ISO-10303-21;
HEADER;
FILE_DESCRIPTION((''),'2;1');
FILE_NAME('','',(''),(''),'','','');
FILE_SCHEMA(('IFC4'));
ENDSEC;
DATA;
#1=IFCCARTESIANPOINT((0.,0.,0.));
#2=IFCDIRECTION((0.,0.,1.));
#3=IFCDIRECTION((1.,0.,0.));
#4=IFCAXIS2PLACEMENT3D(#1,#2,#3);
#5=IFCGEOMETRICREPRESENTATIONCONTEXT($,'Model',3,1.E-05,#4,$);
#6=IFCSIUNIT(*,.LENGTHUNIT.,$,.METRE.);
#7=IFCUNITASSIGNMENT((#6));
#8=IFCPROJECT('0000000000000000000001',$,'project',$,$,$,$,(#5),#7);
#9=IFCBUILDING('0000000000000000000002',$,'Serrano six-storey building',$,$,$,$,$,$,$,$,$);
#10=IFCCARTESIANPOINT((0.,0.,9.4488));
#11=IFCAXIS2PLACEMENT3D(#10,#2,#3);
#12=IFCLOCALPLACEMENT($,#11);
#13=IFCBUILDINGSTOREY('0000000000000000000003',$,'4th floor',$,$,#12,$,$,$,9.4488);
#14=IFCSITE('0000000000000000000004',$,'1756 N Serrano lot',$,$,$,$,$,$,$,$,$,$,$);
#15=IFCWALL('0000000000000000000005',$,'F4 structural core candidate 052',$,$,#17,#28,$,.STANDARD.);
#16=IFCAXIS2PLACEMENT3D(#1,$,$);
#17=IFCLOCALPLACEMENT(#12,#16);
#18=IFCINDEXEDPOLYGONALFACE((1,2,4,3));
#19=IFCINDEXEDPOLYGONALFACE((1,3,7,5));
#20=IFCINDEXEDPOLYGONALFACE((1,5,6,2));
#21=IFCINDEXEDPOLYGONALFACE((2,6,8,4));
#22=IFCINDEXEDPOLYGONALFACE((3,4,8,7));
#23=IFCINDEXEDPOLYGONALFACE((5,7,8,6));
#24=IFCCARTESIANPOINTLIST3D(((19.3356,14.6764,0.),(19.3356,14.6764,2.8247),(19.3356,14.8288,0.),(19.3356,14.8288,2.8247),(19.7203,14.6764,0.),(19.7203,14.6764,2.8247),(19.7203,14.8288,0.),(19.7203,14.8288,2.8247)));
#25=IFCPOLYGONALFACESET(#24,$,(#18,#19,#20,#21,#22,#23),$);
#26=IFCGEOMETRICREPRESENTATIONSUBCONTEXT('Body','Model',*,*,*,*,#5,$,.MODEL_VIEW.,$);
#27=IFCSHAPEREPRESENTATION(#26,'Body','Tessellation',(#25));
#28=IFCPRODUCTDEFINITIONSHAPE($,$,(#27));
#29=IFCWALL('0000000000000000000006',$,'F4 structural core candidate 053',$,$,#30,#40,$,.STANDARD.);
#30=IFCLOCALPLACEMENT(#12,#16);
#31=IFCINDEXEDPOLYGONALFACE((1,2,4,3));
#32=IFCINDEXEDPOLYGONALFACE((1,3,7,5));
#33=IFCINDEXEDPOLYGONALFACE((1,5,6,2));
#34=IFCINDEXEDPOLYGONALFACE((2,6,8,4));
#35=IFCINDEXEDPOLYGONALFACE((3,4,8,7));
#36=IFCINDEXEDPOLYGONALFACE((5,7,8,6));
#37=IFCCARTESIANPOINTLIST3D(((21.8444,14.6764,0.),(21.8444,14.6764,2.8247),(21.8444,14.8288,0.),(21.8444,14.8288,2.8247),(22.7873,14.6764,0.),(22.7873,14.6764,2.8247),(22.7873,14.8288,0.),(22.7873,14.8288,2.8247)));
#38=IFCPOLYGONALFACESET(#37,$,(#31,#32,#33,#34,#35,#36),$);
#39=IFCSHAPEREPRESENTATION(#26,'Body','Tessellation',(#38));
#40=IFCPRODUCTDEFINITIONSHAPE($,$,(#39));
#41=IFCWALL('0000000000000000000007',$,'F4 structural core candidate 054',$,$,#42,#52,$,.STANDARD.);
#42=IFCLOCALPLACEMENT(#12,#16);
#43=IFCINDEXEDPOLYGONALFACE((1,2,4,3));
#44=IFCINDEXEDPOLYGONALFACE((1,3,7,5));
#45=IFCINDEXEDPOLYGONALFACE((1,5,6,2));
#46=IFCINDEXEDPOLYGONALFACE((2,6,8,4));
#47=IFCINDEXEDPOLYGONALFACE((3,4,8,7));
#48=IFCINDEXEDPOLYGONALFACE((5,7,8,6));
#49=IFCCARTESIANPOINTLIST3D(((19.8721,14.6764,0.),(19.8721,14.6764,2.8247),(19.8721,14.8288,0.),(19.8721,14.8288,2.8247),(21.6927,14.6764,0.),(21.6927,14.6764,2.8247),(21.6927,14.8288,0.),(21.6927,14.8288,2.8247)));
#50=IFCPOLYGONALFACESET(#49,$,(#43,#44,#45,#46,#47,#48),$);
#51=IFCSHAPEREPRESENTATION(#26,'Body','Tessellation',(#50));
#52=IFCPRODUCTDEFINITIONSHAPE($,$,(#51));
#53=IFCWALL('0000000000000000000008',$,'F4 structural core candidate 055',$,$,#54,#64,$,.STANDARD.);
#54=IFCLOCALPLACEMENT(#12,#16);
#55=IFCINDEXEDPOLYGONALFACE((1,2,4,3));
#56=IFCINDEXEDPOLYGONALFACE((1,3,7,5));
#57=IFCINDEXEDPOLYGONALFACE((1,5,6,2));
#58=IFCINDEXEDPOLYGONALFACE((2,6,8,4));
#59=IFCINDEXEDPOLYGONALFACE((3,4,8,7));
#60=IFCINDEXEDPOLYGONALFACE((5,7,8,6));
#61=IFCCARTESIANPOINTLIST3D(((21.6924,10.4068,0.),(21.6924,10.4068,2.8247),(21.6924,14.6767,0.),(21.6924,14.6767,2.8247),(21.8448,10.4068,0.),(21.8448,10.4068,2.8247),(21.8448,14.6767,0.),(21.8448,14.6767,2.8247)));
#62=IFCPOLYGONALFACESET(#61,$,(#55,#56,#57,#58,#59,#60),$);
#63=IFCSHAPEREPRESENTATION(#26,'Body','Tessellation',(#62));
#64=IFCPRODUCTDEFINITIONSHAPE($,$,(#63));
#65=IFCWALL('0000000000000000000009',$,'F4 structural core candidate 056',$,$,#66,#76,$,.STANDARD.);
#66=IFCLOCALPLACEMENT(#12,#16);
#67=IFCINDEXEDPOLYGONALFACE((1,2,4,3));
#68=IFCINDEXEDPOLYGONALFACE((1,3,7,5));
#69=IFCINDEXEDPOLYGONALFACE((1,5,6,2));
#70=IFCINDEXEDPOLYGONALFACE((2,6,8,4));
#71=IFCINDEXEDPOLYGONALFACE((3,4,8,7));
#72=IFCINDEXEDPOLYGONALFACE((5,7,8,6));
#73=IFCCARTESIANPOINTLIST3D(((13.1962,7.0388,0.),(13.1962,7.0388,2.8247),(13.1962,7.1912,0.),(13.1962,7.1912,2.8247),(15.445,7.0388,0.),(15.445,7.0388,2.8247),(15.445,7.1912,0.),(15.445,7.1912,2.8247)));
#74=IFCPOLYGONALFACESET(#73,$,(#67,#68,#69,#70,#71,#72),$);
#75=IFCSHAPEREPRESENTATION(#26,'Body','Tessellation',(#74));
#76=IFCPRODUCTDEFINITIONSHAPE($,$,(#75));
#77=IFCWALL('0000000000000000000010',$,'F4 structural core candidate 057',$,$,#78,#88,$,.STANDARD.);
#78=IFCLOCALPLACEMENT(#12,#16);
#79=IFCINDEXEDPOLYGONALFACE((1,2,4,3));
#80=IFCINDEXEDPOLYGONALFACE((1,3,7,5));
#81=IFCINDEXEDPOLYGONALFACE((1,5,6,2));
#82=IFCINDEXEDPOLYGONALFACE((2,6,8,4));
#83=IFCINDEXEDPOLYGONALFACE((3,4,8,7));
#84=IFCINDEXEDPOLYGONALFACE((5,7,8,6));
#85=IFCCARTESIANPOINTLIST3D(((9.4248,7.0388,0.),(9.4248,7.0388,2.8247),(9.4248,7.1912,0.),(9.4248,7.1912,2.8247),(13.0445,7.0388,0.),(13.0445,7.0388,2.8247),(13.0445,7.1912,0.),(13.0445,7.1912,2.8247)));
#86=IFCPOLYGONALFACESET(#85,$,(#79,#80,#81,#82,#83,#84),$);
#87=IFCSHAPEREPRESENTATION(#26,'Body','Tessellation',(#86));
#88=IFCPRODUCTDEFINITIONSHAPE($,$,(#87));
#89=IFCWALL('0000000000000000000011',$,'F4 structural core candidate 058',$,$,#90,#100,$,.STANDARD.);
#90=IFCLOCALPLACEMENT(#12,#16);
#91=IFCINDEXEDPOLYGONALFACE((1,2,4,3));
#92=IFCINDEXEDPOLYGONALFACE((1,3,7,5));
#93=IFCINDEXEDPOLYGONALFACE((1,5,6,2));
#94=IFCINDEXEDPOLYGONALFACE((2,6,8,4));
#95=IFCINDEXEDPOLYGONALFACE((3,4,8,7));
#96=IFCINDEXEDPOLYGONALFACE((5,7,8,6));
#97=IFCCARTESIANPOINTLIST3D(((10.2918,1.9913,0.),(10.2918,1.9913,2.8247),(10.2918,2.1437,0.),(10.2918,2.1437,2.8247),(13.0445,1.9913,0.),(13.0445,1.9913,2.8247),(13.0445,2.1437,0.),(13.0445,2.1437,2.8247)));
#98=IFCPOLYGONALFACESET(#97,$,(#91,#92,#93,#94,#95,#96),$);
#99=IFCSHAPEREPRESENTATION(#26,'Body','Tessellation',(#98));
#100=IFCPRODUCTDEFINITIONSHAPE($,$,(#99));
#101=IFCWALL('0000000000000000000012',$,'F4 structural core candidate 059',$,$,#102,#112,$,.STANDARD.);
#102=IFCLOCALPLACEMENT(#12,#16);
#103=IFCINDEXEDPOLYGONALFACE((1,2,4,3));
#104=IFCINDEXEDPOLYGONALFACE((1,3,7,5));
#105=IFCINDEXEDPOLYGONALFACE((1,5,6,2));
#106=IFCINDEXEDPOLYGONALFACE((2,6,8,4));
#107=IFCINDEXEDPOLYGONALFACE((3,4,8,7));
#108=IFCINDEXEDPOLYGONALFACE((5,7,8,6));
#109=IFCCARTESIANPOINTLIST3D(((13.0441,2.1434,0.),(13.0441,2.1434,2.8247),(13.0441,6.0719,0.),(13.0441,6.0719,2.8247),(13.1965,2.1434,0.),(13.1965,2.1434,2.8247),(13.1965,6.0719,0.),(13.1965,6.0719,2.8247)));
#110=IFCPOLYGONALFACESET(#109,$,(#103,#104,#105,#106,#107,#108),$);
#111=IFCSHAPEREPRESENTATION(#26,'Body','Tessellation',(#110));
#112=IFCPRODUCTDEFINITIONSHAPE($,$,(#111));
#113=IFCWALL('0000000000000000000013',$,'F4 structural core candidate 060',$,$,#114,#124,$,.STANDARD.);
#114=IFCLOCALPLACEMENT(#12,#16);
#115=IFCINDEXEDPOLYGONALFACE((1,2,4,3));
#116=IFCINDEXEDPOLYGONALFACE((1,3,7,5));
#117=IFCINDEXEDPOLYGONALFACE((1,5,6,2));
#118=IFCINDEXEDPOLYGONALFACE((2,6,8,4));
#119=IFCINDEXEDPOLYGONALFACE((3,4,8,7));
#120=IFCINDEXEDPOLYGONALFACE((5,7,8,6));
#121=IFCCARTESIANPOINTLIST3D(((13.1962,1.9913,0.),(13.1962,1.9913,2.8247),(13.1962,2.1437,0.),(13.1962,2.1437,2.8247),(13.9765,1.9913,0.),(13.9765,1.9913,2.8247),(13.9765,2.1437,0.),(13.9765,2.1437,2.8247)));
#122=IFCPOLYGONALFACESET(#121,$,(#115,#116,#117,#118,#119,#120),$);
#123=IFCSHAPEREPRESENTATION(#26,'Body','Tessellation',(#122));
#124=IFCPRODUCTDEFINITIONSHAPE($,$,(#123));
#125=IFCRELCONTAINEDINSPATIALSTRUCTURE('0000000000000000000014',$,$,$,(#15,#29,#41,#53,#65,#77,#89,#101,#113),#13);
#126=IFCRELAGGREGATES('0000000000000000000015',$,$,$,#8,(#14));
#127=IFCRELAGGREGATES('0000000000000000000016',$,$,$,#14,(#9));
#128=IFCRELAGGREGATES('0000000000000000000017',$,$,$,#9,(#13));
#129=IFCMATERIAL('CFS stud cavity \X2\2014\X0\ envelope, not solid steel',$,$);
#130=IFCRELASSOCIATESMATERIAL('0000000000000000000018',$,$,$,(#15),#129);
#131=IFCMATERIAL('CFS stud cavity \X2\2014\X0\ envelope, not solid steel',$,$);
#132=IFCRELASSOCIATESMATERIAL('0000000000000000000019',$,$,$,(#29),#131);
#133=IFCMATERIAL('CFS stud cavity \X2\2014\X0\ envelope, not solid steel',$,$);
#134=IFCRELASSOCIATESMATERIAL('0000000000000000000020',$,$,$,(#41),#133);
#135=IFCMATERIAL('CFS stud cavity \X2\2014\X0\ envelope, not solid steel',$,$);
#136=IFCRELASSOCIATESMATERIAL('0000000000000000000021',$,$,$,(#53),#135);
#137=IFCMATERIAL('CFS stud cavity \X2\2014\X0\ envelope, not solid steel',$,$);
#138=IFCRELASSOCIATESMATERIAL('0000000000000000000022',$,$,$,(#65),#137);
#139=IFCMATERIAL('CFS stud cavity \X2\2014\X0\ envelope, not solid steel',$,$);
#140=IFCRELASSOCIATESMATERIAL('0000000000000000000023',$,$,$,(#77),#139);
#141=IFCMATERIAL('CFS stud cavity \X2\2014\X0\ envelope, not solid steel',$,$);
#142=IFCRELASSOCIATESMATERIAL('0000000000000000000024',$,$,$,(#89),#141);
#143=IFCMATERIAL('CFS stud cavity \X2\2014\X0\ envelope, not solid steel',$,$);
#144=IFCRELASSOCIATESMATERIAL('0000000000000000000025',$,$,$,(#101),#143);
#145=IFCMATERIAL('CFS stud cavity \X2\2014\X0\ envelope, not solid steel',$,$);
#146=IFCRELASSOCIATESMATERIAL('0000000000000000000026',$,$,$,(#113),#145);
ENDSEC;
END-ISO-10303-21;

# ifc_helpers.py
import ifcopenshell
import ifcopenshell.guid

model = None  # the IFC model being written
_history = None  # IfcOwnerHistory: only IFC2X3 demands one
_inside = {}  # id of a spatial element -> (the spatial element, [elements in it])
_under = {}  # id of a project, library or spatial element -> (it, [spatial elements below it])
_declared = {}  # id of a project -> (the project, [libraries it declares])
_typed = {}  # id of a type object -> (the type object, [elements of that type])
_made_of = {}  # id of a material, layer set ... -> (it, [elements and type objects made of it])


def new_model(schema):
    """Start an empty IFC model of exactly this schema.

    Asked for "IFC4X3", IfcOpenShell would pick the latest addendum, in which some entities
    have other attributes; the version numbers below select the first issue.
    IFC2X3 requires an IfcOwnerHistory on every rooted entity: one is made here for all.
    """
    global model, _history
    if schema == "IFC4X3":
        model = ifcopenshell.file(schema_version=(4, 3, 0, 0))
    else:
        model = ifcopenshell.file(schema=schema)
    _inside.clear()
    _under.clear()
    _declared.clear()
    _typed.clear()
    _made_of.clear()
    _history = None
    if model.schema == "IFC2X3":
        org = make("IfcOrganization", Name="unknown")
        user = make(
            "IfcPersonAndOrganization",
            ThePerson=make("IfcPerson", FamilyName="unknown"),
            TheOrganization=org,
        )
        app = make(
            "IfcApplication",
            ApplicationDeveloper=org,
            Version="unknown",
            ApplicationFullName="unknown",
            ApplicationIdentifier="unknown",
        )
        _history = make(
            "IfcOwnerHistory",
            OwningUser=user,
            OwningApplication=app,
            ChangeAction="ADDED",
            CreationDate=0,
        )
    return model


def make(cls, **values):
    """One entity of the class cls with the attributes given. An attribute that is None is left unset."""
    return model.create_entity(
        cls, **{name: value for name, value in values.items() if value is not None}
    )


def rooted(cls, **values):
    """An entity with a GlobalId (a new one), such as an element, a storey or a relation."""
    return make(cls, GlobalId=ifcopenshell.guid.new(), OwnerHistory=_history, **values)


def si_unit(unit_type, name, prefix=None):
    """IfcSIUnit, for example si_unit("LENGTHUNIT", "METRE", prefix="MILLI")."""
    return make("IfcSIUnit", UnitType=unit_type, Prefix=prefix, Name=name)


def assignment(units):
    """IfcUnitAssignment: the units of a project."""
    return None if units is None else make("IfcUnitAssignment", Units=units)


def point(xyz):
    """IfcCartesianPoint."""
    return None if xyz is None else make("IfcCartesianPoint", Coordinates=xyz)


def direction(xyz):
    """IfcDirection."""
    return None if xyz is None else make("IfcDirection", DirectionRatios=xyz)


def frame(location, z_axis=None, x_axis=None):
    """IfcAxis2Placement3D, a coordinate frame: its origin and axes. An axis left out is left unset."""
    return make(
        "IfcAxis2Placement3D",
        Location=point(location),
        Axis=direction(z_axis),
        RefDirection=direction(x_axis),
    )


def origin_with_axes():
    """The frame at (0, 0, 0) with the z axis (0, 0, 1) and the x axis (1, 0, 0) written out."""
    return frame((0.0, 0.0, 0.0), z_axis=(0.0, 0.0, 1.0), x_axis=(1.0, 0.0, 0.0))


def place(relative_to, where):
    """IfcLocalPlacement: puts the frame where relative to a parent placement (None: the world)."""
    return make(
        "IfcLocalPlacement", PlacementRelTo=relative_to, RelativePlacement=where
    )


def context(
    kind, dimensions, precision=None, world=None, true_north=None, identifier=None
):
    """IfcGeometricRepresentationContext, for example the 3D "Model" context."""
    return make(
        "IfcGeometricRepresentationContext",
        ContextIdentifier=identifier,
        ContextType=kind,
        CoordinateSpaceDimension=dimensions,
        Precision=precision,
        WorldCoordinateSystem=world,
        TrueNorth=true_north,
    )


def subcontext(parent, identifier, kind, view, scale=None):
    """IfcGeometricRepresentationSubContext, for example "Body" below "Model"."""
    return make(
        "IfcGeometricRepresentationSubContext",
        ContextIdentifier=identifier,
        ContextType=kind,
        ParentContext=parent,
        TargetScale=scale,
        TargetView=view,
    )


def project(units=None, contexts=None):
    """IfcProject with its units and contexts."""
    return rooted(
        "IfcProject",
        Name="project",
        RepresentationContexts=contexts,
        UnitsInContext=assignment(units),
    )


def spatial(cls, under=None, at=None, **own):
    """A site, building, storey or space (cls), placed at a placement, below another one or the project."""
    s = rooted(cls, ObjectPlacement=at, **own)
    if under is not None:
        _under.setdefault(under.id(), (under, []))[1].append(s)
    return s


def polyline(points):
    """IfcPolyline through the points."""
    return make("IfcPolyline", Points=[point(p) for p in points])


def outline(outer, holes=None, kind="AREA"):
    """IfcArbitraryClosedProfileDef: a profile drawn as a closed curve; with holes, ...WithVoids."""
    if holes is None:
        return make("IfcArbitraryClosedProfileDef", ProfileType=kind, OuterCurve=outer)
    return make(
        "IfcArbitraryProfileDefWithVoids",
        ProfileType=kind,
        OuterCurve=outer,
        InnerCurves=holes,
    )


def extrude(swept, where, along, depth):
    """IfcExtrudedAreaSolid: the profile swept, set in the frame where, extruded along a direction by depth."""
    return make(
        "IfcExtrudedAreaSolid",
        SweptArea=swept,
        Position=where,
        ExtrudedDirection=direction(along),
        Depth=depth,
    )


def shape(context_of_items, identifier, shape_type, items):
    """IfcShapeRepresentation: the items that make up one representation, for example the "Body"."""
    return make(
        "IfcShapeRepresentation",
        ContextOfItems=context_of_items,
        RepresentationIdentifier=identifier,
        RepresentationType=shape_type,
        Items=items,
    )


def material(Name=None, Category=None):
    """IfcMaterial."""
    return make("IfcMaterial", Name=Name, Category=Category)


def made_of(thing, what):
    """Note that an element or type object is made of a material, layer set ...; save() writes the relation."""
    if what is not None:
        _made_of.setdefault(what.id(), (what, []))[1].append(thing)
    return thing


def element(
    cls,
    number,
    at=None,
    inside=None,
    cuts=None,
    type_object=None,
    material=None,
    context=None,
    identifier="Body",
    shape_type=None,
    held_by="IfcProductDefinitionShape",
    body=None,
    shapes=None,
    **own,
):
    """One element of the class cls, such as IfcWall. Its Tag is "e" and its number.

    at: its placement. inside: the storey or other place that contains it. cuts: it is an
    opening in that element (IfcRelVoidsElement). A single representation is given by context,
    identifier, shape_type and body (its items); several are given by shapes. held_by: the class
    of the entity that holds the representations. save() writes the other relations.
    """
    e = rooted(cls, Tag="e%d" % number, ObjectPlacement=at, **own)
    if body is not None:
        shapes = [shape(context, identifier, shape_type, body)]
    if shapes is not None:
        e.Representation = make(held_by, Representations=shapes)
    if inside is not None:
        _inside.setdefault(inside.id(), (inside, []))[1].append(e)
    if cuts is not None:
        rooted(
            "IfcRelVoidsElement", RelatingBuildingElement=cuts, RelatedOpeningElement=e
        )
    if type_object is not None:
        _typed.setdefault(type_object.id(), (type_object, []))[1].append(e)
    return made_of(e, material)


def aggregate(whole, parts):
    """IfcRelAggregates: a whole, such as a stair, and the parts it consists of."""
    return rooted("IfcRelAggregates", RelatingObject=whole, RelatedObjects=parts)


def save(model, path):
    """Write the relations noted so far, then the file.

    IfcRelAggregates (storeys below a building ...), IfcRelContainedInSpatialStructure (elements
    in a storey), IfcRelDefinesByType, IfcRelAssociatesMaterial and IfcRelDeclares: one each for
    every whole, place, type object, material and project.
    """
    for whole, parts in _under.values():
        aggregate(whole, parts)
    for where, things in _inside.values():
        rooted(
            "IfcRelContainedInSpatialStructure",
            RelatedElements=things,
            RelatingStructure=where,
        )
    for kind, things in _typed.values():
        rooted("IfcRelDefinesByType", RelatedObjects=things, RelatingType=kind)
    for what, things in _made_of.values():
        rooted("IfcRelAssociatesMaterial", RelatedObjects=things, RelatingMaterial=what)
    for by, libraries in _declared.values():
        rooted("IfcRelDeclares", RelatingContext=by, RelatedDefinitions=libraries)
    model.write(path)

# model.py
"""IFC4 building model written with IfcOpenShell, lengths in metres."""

from ifc_helpers import new_model, si_unit, frame, origin_with_axes, place, context, subcontext, project, spatial, polyline, outline, extrude, material, element, save


model = new_model("IFC4")

# Units and contexts
model_context = context("Model", 3, precision=1e-05, world=origin_with_axes())
body_context = subcontext(model_context, "Body", "Model", "MODEL_VIEW")
ifc_project = project(units=[si_unit("LENGTHUNIT", "METRE")], contexts=[model_context])

# Site, building, storey
site = spatial("IfcSite", under=ifc_project, Name="1756 N Serrano lot")
building = spatial("IfcBuilding", under=site, Name="Serrano six-storey building")
storey_placement = place(None, frame((0.0, 0.0, 9.4488), z_axis=(0.0, 0.0, 1.0), x_axis=(1.0, 0.0, 0.0)))
storey = spatial("IfcBuildingStorey", under=building, at=storey_placement, Name="4th floor", Elevation=9.4488)

# Walls
ifc_material_1 = material(Name="CFS stud cavity — envelope, not solid steel")
wall_1_placement = place(storey_placement, frame((0.0, 0.0, -9.4488), z_axis=(0.0, 0.0, 1.0), x_axis=(1.0, 0.0, 0.0)))
element("IfcWall", 1, at=wall_1_placement, inside=storey, material=ifc_material_1, Name="F4 structural core candidate 052", PredefinedType="STANDARD", context=body_context, shape_type="SweptSolid", body=[
    extrude(outline(polyline([(19.7203, 14.8288), (19.7203, 14.6764), (19.3356, 14.6764), (19.3356, 14.8288), (19.7203, 14.8288)])), frame((0.0, 0.0, 9.4488)), (0.0, 0.0, 1.0), 2.8247),
])
ifc_material_2 = material(Name="CFS stud cavity — envelope, not solid steel")
wall_2_placement = place(storey_placement, frame((0.0, 0.0, -9.4488), z_axis=(0.0, 0.0, 1.0), x_axis=(1.0, 0.0, 0.0)))
element("IfcWall", 2, at=wall_2_placement, inside=storey, material=ifc_material_2, Name="F4 structural core candidate 053", PredefinedType="STANDARD", context=body_context, shape_type="SweptSolid", body=[
    extrude(outline(polyline([(22.7873, 14.8288), (22.7873, 14.6764), (21.8444, 14.6764), (21.8444, 14.8288), (22.7873, 14.8288)])), frame((0.0, 0.0, 9.4488)), (0.0, 0.0, 1.0), 2.8247),
])
ifc_material_3 = material(Name="CFS stud cavity — envelope, not solid steel")
wall_3_placement = place(storey_placement, frame((0.0, 0.0, -9.4488), z_axis=(0.0, 0.0, 1.0), x_axis=(1.0, 0.0, 0.0)))
element("IfcWall", 3, at=wall_3_placement, inside=storey, material=ifc_material_3, Name="F4 structural core candidate 054", PredefinedType="STANDARD", context=body_context, shape_type="SweptSolid", body=[
    extrude(outline(polyline([(21.6927, 14.8288), (21.6927, 14.6764), (19.8721, 14.6764), (19.8721, 14.8288), (21.6927, 14.8288)])), frame((0.0, 0.0, 9.4488)), (0.0, 0.0, 1.0), 2.8247),
])
ifc_material_4 = material(Name="CFS stud cavity — envelope, not solid steel")
wall_4_placement = place(storey_placement, frame((0.0, 0.0, -9.4488), z_axis=(0.0, 0.0, 1.0), x_axis=(1.0, 0.0, 0.0)))
element("IfcWall", 4, at=wall_4_placement, inside=storey, material=ifc_material_4, Name="F4 structural core candidate 055", PredefinedType="STANDARD", context=body_context, shape_type="SweptSolid", body=[
    extrude(outline(polyline([(21.8448, 10.4068), (21.6924, 10.4068), (21.6924, 14.6767), (21.8448, 14.6767), (21.8448, 10.4068)])), frame((0.0, 0.0, 9.4488)), (0.0, 0.0, 1.0), 2.8247),
])
ifc_material_5 = material(Name="CFS stud cavity — envelope, not solid steel")
wall_5_placement = place(storey_placement, frame((0.0, 0.0, -9.4488), z_axis=(0.0, 0.0, 1.0), x_axis=(1.0, 0.0, 0.0)))
element("IfcWall", 5, at=wall_5_placement, inside=storey, material=ifc_material_5, Name="F4 structural core candidate 056", PredefinedType="STANDARD", context=body_context, shape_type="SweptSolid", body=[
    extrude(outline(polyline([(15.445, 7.1912), (15.445, 7.0388), (13.1962, 7.0388), (13.1962, 7.1912), (15.445, 7.1912)])), frame((0.0, 0.0, 9.4488)), (0.0, 0.0, 1.0), 2.8247),
])
ifc_material_6 = material(Name="CFS stud cavity — envelope, not solid steel")
wall_6_placement = place(storey_placement, frame((0.0, 0.0, -9.4488), z_axis=(0.0, 0.0, 1.0), x_axis=(1.0, 0.0, 0.0)))
element("IfcWall", 6, at=wall_6_placement, inside=storey, material=ifc_material_6, Name="F4 structural core candidate 057", PredefinedType="STANDARD", context=body_context, shape_type="SweptSolid", body=[
    extrude(outline(polyline([(13.0445, 7.1912), (13.0445, 7.0388), (9.4248, 7.0388), (9.4248, 7.1912), (13.0445, 7.1912)])), frame((0.0, 0.0, 9.4488)), (0.0, 0.0, 1.0), 2.8247),
])
ifc_material_7 = material(Name="CFS stud cavity — envelope, not solid steel")
wall_7_placement = place(storey_placement, frame((0.0, 0.0, -9.4488), z_axis=(0.0, 0.0, 1.0), x_axis=(1.0, 0.0, 0.0)))
element("IfcWall", 7, at=wall_7_placement, inside=storey, material=ifc_material_7, Name="F4 structural core candidate 058", PredefinedType="STANDARD", context=body_context, shape_type="SweptSolid", body=[
    extrude(outline(polyline([(13.0445, 2.1437), (13.0445, 1.9913), (10.2918, 1.9913), (10.2918, 2.1437), (13.0445, 2.1437)])), frame((0.0, 0.0, 9.4488)), (0.0, 0.0, 1.0), 2.8247),
])
ifc_material_8 = material(Name="CFS stud cavity — envelope, not solid steel")
wall_8_placement = place(storey_placement, frame((0.0, 0.0, -9.4488), z_axis=(0.0, 0.0, 1.0), x_axis=(1.0, 0.0, 0.0)))
element("IfcWall", 8, at=wall_8_placement, inside=storey, material=ifc_material_8, Name="F4 structural core candidate 059", PredefinedType="STANDARD", context=body_context, shape_type="SweptSolid", body=[
    extrude(outline(polyline([(13.1965, 2.1434), (13.0441, 2.1434), (13.0441, 6.0719), (13.1965, 6.0719), (13.1965, 2.1434)])), frame((0.0, 0.0, 9.4488)), (0.0, 0.0, 1.0), 2.8247),
])
ifc_material_9 = material(Name="CFS stud cavity — envelope, not solid steel")
wall_9_placement = place(storey_placement, frame((0.0, 0.0, -9.4488), z_axis=(0.0, 0.0, 1.0), x_axis=(1.0, 0.0, 0.0)))
element("IfcWall", 9, at=wall_9_placement, inside=storey, material=ifc_material_9, Name="F4 structural core candidate 060", PredefinedType="STANDARD", context=body_context, shape_type="SweptSolid", body=[
    extrude(outline(polyline([(13.9765, 2.1437), (13.9765, 1.9913), (13.1962, 1.9913), (13.1962, 2.1437), (13.9765, 2.1437)])), frame((0.0, 0.0, 9.4488)), (0.0, 0.0, 1.0), 2.8247),
])

save(model, "model.ifc")
